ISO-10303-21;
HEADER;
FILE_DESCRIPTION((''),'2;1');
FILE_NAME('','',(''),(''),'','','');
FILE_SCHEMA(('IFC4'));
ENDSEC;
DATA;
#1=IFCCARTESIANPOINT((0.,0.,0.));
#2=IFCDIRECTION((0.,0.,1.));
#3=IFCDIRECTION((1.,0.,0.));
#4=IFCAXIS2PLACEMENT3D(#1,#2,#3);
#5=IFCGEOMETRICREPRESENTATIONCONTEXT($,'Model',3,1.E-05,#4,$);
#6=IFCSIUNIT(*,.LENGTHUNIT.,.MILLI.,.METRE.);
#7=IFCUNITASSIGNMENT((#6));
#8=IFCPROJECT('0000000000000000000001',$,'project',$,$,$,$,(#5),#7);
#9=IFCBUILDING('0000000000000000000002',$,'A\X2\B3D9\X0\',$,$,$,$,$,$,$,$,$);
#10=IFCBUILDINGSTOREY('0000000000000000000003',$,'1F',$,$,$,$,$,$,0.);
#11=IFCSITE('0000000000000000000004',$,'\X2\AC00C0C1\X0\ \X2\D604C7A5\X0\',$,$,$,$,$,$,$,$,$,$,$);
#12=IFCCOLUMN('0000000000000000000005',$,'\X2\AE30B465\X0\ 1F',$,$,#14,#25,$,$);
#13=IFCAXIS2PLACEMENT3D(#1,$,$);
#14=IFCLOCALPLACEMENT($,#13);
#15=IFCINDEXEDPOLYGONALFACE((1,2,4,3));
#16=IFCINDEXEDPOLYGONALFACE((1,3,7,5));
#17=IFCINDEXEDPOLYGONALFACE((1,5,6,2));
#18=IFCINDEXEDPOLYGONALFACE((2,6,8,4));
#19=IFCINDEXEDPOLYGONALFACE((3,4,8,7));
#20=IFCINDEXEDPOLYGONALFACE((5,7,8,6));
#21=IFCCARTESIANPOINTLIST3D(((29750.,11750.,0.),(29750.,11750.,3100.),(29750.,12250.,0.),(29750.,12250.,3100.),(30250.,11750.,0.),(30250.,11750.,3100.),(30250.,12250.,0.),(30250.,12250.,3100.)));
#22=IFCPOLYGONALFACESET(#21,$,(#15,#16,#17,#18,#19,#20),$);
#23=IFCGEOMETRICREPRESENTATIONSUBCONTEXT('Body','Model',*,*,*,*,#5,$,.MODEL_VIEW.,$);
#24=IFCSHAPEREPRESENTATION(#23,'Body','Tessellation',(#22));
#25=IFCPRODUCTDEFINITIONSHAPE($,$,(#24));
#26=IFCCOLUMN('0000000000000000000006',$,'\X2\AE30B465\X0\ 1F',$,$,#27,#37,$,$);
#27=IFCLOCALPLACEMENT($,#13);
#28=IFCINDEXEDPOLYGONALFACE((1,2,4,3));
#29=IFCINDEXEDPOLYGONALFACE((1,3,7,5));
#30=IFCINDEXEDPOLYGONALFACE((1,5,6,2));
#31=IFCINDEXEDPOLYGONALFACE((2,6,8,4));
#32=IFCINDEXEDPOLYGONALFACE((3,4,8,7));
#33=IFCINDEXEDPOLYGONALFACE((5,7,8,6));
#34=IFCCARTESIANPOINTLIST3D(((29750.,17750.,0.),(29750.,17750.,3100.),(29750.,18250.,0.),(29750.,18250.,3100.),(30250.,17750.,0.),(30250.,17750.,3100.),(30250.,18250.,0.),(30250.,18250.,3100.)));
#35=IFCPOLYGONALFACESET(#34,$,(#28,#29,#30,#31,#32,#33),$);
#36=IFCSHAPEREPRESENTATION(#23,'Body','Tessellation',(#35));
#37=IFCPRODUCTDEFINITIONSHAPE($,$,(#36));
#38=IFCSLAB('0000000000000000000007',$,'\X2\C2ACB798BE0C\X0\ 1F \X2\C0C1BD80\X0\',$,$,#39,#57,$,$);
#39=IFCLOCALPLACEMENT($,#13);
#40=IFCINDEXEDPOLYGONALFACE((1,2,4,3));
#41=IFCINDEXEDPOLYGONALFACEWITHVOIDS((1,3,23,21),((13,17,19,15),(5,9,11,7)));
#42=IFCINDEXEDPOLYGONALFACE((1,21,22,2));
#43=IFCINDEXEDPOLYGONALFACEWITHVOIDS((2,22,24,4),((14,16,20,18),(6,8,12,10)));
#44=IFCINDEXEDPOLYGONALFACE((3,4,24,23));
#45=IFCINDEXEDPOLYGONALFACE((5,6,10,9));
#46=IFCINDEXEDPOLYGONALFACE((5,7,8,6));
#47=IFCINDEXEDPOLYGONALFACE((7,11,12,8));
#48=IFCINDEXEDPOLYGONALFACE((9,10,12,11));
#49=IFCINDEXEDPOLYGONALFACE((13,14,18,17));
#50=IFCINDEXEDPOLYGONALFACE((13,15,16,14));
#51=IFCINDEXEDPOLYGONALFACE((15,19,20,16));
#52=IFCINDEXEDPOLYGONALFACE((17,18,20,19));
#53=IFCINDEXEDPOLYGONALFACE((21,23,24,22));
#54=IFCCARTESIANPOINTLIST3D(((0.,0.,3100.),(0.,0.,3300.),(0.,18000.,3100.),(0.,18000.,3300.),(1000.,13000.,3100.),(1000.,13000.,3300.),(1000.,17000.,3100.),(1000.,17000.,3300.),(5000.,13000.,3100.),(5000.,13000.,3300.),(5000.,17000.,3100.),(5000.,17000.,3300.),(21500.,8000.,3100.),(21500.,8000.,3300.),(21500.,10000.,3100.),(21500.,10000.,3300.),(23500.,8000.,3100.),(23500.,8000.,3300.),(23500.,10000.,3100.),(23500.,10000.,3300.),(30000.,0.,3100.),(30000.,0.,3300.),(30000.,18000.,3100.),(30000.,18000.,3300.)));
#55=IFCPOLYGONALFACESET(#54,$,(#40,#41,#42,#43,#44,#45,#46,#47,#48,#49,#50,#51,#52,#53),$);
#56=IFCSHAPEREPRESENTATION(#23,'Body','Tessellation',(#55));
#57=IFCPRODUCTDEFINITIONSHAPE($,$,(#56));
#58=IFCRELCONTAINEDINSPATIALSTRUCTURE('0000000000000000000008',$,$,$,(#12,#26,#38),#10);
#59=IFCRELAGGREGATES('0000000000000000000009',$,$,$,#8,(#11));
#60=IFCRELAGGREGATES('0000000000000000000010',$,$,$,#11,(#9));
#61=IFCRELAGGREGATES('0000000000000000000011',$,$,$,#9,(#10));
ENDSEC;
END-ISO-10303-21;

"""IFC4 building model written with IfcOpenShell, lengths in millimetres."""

from ifc_helpers import new_model, si_unit, frame, origin_with_axes, place, context, subcontext, project, spatial, indexed_curve, outline, extrude, element, save


model = new_model("IFC4")

# Units and contexts
model_context = context("Model", 3, precision=1e-05, world=origin_with_axes())
body_context = subcontext(model_context, "Body", "Model", "MODEL_VIEW")
ifc_project = project(units=[si_unit("LENGTHUNIT", "METRE", prefix="MILLI")], contexts=[model_context])

# Site, building, storey
site = spatial("IfcSite", under=ifc_project, Name="가상 현장")
building = spatial("IfcBuilding", under=site, Name="A동")
storey = spatial("IfcBuildingStorey", under=building, Name="1F", Elevation=0.0)

# Columns
for number, where, z_axis, x_axis, name in (
    (1, (29750.0, 11750.0, 0.0), (0.0, 0.0, 1.0), (1.0, 0.0, 0.0), "기둥 1F"),
    (2, (29750.0, 17750.0, 0.0), (0.0, 0.0, 1.0), (1.0, 0.0, 0.0), "기둥 1F"),
):
    element("IfcColumn", number, at=place(None, frame(where, z_axis=z_axis, x_axis=x_axis)), inside=storey, Name=name, context=body_context, shape_type="SweptSolid", body=[
        extrude(outline(indexed_curve([(0.0, 0.0), (0.0, 500.0), (500.0, 500.0), (500.0, 0.0), (0.0, 0.0)], self_intersect=False)), origin_with_axes(), (0.0, 0.0, 1.0), 3100.0),
    ])

# Slab, openings
slab_placement = place(None, frame((0.0, 0.0, 3100.0), z_axis=(0.0, 0.0, 1.0), x_axis=(1.0, 0.0, 0.0)))
slab = element("IfcSlab", 3, at=slab_placement, inside=storey, Name="슬래브 1F 상부", context=body_context, shape_type="SweptSolid", body=[
    extrude(outline(indexed_curve([(0.0, 0.0), (30000.0, 0.0), (30000.0, 18000.0), (0.0, 18000.0)])), None, (0.0, 0.0, 1.0), 200.0),
])
opening_1_placement = place(slab_placement, frame((1000.0, 13000.0, -10.0), z_axis=(0.0, 0.0, 1.0), x_axis=(1.0, 0.0, 0.0)))
element("IfcOpeningElement", 4, at=opening_1_placement, cuts=slab, context=body_context, shape_type="SweptSolid", body=[
    extrude(outline(indexed_curve([(0.0, 0.0), (4000.0, 0.0), (4000.0, 4000.0), (0.0, 4000.0)])), None, (0.0, 0.0, 1.0), 220.0),
])
opening_2_placement = place(slab_placement, frame((21500.0, 8000.0, -10.0), z_axis=(0.0, 0.0, 1.0), x_axis=(1.0, 0.0, 0.0)))
element("IfcOpeningElement", 5, at=opening_2_placement, cuts=slab, context=body_context, shape_type="SweptSolid", body=[
    extrude(outline(indexed_curve([(0.0, 0.0), (2000.0, 0.0), (2000.0, 2000.0), (0.0, 2000.0)])), None, (0.0, 0.0, 1.0), 220.0),
])

save(model, "model.ifc")
